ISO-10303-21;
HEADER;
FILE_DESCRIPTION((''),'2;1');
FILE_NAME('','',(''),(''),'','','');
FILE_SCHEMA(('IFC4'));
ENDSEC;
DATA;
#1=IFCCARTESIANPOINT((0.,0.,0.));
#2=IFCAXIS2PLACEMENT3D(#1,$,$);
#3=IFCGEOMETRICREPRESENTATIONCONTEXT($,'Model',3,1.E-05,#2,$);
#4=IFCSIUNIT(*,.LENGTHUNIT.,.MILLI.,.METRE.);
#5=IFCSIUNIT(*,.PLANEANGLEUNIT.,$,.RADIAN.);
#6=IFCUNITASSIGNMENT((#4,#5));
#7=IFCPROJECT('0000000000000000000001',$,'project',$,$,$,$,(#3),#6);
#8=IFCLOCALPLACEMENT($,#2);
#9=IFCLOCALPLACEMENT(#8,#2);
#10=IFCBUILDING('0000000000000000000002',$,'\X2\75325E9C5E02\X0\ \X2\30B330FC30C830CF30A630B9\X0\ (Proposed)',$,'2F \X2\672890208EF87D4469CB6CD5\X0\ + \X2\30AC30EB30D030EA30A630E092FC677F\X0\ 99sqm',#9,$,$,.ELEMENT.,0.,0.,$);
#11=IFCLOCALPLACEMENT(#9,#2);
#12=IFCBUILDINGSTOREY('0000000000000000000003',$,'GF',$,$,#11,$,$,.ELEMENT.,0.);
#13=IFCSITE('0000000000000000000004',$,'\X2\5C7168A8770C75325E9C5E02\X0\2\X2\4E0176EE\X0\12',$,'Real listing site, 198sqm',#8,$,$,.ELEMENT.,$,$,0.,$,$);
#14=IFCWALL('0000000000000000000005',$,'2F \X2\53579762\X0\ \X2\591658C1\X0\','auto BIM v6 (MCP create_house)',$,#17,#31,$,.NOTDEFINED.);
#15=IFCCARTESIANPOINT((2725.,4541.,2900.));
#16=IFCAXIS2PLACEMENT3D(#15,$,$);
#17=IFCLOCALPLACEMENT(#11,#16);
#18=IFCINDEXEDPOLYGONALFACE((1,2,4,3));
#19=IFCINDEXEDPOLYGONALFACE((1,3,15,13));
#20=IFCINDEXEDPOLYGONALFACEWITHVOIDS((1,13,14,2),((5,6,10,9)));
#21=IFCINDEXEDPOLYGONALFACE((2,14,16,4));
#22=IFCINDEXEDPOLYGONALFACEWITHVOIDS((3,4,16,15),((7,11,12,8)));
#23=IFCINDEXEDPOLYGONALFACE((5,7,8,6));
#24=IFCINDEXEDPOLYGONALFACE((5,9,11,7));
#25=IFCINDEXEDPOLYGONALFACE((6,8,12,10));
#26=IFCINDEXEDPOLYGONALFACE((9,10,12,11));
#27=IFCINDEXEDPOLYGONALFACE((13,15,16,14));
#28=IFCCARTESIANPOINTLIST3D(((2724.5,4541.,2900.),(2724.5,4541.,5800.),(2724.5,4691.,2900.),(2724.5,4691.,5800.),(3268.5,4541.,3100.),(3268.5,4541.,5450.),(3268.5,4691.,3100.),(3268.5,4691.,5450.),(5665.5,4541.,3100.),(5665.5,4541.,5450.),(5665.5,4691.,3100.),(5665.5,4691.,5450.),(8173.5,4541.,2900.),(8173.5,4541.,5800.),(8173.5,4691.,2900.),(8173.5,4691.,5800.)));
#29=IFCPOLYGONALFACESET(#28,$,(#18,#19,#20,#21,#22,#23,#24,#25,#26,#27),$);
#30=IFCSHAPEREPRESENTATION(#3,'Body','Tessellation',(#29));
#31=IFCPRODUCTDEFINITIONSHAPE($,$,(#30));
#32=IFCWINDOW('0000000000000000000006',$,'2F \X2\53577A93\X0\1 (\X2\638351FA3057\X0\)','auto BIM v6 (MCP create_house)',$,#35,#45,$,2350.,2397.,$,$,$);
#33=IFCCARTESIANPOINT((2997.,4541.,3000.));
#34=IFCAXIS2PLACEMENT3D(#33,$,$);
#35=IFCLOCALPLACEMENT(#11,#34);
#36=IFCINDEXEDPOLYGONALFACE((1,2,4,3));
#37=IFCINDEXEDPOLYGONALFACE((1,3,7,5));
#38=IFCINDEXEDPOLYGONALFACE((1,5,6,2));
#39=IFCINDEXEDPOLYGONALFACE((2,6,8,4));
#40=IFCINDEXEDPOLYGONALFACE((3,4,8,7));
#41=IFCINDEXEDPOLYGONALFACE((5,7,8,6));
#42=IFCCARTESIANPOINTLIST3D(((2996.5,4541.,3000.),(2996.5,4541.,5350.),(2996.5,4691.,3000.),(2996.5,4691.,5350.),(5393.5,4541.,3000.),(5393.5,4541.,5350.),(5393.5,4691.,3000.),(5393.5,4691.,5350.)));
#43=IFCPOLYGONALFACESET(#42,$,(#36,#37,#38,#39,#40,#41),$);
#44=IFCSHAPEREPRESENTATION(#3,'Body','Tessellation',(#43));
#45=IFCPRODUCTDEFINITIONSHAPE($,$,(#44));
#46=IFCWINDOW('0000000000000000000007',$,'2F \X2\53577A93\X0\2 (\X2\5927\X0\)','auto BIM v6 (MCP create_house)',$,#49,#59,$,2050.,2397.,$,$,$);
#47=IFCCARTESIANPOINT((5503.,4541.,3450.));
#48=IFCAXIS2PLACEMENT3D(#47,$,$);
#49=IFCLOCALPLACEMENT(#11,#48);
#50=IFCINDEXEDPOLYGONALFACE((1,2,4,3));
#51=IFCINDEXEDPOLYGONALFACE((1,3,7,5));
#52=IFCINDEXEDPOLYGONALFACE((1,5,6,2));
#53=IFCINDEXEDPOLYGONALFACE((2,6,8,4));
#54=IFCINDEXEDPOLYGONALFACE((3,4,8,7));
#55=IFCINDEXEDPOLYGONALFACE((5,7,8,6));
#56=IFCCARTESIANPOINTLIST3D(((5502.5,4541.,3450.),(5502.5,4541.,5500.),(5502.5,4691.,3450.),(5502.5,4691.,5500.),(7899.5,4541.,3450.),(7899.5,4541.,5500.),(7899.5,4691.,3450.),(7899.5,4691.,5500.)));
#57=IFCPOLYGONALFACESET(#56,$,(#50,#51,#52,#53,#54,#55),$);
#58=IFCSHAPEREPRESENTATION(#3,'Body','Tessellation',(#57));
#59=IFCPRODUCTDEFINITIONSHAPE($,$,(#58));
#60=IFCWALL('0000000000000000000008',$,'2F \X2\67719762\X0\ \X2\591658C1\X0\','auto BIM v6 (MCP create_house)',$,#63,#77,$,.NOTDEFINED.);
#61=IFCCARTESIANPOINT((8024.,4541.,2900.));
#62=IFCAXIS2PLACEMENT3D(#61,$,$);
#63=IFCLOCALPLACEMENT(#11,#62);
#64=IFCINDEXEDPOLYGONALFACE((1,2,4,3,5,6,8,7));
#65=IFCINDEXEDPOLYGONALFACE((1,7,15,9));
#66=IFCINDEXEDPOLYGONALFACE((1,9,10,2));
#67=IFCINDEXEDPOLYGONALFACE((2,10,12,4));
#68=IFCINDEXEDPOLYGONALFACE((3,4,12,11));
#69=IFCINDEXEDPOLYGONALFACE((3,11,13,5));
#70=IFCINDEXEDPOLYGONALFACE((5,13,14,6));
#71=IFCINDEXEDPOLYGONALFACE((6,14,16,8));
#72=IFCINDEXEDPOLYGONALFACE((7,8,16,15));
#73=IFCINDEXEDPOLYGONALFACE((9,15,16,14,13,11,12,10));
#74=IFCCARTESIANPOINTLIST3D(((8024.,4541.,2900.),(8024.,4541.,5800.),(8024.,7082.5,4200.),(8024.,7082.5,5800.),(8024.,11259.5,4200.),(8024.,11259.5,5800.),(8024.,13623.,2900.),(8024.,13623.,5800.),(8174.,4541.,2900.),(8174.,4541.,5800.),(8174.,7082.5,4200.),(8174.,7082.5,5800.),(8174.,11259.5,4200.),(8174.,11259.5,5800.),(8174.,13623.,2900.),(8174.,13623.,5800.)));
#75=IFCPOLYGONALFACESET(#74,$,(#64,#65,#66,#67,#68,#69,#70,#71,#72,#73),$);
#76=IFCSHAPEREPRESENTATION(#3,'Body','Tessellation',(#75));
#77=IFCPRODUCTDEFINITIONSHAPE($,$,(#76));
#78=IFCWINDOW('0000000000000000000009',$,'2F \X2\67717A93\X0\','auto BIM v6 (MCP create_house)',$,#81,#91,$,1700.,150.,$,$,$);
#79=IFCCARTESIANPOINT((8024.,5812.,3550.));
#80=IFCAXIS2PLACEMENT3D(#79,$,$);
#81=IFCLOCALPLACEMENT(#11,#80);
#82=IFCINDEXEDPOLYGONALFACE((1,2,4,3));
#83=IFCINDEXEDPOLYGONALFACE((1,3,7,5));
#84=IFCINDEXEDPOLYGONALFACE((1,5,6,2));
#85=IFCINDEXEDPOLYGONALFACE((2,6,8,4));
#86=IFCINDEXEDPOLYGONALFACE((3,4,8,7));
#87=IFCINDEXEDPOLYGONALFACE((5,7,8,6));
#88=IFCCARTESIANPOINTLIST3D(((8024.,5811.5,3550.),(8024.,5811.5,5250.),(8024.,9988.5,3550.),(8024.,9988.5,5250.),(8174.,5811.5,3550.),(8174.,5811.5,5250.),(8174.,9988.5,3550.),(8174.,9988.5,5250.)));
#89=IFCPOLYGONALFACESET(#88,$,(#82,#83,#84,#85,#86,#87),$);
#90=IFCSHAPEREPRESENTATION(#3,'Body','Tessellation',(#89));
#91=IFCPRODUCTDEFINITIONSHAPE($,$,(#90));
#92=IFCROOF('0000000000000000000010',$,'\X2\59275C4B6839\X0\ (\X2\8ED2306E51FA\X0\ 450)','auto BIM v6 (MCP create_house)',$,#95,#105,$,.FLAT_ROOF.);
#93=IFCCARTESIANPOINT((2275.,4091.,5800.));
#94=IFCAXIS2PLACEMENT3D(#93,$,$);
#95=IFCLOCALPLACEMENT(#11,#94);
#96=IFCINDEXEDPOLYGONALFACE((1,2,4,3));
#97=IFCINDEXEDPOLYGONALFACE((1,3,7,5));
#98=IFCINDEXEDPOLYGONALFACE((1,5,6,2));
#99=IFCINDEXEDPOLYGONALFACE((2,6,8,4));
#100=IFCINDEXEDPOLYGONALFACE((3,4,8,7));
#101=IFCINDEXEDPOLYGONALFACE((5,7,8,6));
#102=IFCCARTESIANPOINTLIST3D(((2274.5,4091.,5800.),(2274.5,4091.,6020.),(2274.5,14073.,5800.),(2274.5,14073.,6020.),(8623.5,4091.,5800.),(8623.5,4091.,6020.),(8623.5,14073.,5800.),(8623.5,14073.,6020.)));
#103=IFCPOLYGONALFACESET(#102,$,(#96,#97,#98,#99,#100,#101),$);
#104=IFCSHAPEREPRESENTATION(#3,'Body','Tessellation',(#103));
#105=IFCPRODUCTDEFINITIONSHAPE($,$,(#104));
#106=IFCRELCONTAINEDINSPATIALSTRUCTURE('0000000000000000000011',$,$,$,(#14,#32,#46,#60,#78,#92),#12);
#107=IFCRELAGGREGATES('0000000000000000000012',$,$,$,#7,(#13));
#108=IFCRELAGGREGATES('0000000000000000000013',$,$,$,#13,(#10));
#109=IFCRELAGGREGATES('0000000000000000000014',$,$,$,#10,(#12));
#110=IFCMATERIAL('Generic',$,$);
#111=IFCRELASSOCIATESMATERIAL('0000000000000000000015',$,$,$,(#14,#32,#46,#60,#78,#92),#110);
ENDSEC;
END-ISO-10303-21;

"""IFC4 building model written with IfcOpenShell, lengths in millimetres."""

from ifc_helpers import new_model, si_unit, frame, frame_2d, origin, place, context, project, spatial, rectangle, extrude, material, element, fill, save


model = new_model("IFC4")

# Units and contexts
model_context = context("Model", 3, precision=1e-05, world=origin())
ifc_project = project(units=[si_unit("LENGTHUNIT", "METRE", prefix="MILLI"), si_unit("PLANEANGLEUNIT", "RADIAN")], contexts=[model_context])

# Site, building, storey
site_placement = place(None, origin())
site = spatial("IfcSite", under=ifc_project, at=site_placement, Name="山梨県甲府市2丁目12", ObjectType="Real listing site, 198sqm", CompositionType="ELEMENT", RefElevation=0.0)
building_placement = place(site_placement, origin())
building = spatial("IfcBuilding", under=site, at=building_placement, Name="甲府市 コートハウス (Proposed)", ObjectType="2F 木造軸組構法 + ガルバリウム鋼板 99sqm", CompositionType="ELEMENT", ElevationOfRefHeight=0.0, ElevationOfTerrain=0.0)
storey_placement = place(building_placement, origin())
storey = spatial("IfcBuildingStorey", under=building, at=storey_placement, Name="GF", CompositionType="ELEMENT", Elevation=0.0)

# Shared definitions
ifc_material = material(Name="Generic")

# Wall, openings, windows
wall_1_placement = place(storey_placement, frame((2725.0, 4541.0, 2900.0)))
wall_1 = element("IfcWall", 1, at=wall_1_placement, inside=storey, material=ifc_material, Name="2F 南面 外壁", Description="auto BIM v6 (MCP create_house)", PredefinedType="NOTDEFINED", context=model_context, shape_type="SweptSolid", body=[
    extrude(rectangle(XDim=5449.0, YDim=150.0, at=frame_2d((2724.0, 75.0))), frame((2725.0, 4541.0, 2900.0)), (0.0, 0.0, 1.0), 2900.0),
])
opening_1_placement = place(storey_placement, frame((2997.0, 4541.0, 3000.0)))
opening_1 = element("IfcOpeningElement", 2, at=opening_1_placement, cuts=wall_1, PredefinedType="NOTDEFINED", context=model_context, shape_type="SweptSolid", body=[
    extrude(rectangle(XDim=2397.0, YDim=150.0, at=frame_2d((1198.0, 75.0))), frame((2997.0, 4541.0, 3000.0)), (0.0, 0.0, 1.0), 2350.0),
])
opening_2_placement = place(storey_placement, frame((5503.0, 4541.0, 3450.0)))
opening_2 = element("IfcOpeningElement", 3, at=opening_2_placement, cuts=wall_1, PredefinedType="NOTDEFINED", context=model_context, shape_type="SweptSolid", body=[
    extrude(rectangle(XDim=2397.0, YDim=150.0, at=frame_2d((1198.0, 75.0))), frame((5503.0, 4541.0, 3450.0)), (0.0, 0.0, 1.0), 2050.0),
])
window_1_placement = place(storey_placement, frame((2997.0, 4541.0, 3000.0)))
window_1 = element("IfcWindow", 4, at=window_1_placement, inside=storey, material=ifc_material, Name="2F 南窓1 (掃出し)", Description="auto BIM v6 (MCP create_house)", OverallHeight=2350.0, OverallWidth=2397.0, context=model_context, shape_type="SweptSolid", body=[
    extrude(rectangle(XDim=2397.0, YDim=150.0, at=frame_2d((1198.0, 75.0))), frame((2997.0, 4541.0, 3000.0)), (0.0, 0.0, 1.0), 2350.0),
])
fill(opening_1, window_1)
window_2_placement = place(storey_placement, frame((5503.0, 4541.0, 3450.0)))
window_2 = element("IfcWindow", 5, at=window_2_placement, inside=storey, material=ifc_material, Name="2F 南窓2 (大)", Description="auto BIM v6 (MCP create_house)", OverallHeight=2050.0, OverallWidth=2397.0, context=model_context, shape_type="SweptSolid", body=[
    extrude(rectangle(XDim=2397.0, YDim=150.0, at=frame_2d((1198.0, 75.0))), frame((5503.0, 4541.0, 3450.0)), (0.0, 0.0, 1.0), 2050.0),
])
fill(opening_2, window_2)

# Wall, opening, window
wall_2_placement = place(storey_placement, frame((8024.0, 4541.0, 2900.0)))
wall_2 = element("IfcWall", 6, at=wall_2_placement, inside=storey, material=ifc_material, Name="2F 東面 外壁", Description="auto BIM v6 (MCP create_house)", PredefinedType="NOTDEFINED", context=model_context, shape_type="SweptSolid", body=[
    extrude(rectangle(XDim=150.0, YDim=9082.0, at=frame_2d((75.0, 4541.0))), frame((8024.0, 4541.0, 2900.0)), (0.0, 0.0, 1.0), 2900.0),
])
opening_3_placement = place(storey_placement, frame((8024.0, 5812.0, 3550.0)))
opening_3 = element("IfcOpeningElement", 7, at=opening_3_placement, cuts=wall_2, PredefinedType="NOTDEFINED", context=model_context, shape_type="SweptSolid", body=[
    extrude(rectangle(XDim=150.0, YDim=4177.0, at=frame_2d((75.0, 2088.0))), frame((8024.0, 5812.0, 3550.0)), (0.0, 0.0, 1.0), 1700.0),
])
window_3_placement = place(storey_placement, frame((8024.0, 5812.0, 3550.0)))
window_3 = element("IfcWindow", 8, at=window_3_placement, inside=storey, material=ifc_material, Name="2F 東窓", Description="auto BIM v6 (MCP create_house)", OverallHeight=1700.0, OverallWidth=150.0, context=model_context, shape_type="SweptSolid", body=[
    extrude(rectangle(XDim=150.0, YDim=4177.0, at=frame_2d((75.0, 2088.0))), frame((8024.0, 5812.0, 3550.0)), (0.0, 0.0, 1.0), 1700.0),
])
fill(opening_3, window_3)

# Roof
roof_placement = place(storey_placement, frame((2275.0, 4091.0, 5800.0)))
element("IfcRoof", 9, at=roof_placement, inside=storey, material=ifc_material, Name="大屋根 (軒の出 450)", Description="auto BIM v6 (MCP create_house)", PredefinedType="FLAT_ROOF", context=model_context, shape_type="SweptSolid", body=[
    extrude(rectangle(XDim=6349.0, YDim=9982.0, at=frame_2d((3174.0, 4991.0))), frame((2275.0, 4091.0, 5800.0)), (0.0, 0.0, 1.0), 220.0),
])

save(model, "model.ifc")
